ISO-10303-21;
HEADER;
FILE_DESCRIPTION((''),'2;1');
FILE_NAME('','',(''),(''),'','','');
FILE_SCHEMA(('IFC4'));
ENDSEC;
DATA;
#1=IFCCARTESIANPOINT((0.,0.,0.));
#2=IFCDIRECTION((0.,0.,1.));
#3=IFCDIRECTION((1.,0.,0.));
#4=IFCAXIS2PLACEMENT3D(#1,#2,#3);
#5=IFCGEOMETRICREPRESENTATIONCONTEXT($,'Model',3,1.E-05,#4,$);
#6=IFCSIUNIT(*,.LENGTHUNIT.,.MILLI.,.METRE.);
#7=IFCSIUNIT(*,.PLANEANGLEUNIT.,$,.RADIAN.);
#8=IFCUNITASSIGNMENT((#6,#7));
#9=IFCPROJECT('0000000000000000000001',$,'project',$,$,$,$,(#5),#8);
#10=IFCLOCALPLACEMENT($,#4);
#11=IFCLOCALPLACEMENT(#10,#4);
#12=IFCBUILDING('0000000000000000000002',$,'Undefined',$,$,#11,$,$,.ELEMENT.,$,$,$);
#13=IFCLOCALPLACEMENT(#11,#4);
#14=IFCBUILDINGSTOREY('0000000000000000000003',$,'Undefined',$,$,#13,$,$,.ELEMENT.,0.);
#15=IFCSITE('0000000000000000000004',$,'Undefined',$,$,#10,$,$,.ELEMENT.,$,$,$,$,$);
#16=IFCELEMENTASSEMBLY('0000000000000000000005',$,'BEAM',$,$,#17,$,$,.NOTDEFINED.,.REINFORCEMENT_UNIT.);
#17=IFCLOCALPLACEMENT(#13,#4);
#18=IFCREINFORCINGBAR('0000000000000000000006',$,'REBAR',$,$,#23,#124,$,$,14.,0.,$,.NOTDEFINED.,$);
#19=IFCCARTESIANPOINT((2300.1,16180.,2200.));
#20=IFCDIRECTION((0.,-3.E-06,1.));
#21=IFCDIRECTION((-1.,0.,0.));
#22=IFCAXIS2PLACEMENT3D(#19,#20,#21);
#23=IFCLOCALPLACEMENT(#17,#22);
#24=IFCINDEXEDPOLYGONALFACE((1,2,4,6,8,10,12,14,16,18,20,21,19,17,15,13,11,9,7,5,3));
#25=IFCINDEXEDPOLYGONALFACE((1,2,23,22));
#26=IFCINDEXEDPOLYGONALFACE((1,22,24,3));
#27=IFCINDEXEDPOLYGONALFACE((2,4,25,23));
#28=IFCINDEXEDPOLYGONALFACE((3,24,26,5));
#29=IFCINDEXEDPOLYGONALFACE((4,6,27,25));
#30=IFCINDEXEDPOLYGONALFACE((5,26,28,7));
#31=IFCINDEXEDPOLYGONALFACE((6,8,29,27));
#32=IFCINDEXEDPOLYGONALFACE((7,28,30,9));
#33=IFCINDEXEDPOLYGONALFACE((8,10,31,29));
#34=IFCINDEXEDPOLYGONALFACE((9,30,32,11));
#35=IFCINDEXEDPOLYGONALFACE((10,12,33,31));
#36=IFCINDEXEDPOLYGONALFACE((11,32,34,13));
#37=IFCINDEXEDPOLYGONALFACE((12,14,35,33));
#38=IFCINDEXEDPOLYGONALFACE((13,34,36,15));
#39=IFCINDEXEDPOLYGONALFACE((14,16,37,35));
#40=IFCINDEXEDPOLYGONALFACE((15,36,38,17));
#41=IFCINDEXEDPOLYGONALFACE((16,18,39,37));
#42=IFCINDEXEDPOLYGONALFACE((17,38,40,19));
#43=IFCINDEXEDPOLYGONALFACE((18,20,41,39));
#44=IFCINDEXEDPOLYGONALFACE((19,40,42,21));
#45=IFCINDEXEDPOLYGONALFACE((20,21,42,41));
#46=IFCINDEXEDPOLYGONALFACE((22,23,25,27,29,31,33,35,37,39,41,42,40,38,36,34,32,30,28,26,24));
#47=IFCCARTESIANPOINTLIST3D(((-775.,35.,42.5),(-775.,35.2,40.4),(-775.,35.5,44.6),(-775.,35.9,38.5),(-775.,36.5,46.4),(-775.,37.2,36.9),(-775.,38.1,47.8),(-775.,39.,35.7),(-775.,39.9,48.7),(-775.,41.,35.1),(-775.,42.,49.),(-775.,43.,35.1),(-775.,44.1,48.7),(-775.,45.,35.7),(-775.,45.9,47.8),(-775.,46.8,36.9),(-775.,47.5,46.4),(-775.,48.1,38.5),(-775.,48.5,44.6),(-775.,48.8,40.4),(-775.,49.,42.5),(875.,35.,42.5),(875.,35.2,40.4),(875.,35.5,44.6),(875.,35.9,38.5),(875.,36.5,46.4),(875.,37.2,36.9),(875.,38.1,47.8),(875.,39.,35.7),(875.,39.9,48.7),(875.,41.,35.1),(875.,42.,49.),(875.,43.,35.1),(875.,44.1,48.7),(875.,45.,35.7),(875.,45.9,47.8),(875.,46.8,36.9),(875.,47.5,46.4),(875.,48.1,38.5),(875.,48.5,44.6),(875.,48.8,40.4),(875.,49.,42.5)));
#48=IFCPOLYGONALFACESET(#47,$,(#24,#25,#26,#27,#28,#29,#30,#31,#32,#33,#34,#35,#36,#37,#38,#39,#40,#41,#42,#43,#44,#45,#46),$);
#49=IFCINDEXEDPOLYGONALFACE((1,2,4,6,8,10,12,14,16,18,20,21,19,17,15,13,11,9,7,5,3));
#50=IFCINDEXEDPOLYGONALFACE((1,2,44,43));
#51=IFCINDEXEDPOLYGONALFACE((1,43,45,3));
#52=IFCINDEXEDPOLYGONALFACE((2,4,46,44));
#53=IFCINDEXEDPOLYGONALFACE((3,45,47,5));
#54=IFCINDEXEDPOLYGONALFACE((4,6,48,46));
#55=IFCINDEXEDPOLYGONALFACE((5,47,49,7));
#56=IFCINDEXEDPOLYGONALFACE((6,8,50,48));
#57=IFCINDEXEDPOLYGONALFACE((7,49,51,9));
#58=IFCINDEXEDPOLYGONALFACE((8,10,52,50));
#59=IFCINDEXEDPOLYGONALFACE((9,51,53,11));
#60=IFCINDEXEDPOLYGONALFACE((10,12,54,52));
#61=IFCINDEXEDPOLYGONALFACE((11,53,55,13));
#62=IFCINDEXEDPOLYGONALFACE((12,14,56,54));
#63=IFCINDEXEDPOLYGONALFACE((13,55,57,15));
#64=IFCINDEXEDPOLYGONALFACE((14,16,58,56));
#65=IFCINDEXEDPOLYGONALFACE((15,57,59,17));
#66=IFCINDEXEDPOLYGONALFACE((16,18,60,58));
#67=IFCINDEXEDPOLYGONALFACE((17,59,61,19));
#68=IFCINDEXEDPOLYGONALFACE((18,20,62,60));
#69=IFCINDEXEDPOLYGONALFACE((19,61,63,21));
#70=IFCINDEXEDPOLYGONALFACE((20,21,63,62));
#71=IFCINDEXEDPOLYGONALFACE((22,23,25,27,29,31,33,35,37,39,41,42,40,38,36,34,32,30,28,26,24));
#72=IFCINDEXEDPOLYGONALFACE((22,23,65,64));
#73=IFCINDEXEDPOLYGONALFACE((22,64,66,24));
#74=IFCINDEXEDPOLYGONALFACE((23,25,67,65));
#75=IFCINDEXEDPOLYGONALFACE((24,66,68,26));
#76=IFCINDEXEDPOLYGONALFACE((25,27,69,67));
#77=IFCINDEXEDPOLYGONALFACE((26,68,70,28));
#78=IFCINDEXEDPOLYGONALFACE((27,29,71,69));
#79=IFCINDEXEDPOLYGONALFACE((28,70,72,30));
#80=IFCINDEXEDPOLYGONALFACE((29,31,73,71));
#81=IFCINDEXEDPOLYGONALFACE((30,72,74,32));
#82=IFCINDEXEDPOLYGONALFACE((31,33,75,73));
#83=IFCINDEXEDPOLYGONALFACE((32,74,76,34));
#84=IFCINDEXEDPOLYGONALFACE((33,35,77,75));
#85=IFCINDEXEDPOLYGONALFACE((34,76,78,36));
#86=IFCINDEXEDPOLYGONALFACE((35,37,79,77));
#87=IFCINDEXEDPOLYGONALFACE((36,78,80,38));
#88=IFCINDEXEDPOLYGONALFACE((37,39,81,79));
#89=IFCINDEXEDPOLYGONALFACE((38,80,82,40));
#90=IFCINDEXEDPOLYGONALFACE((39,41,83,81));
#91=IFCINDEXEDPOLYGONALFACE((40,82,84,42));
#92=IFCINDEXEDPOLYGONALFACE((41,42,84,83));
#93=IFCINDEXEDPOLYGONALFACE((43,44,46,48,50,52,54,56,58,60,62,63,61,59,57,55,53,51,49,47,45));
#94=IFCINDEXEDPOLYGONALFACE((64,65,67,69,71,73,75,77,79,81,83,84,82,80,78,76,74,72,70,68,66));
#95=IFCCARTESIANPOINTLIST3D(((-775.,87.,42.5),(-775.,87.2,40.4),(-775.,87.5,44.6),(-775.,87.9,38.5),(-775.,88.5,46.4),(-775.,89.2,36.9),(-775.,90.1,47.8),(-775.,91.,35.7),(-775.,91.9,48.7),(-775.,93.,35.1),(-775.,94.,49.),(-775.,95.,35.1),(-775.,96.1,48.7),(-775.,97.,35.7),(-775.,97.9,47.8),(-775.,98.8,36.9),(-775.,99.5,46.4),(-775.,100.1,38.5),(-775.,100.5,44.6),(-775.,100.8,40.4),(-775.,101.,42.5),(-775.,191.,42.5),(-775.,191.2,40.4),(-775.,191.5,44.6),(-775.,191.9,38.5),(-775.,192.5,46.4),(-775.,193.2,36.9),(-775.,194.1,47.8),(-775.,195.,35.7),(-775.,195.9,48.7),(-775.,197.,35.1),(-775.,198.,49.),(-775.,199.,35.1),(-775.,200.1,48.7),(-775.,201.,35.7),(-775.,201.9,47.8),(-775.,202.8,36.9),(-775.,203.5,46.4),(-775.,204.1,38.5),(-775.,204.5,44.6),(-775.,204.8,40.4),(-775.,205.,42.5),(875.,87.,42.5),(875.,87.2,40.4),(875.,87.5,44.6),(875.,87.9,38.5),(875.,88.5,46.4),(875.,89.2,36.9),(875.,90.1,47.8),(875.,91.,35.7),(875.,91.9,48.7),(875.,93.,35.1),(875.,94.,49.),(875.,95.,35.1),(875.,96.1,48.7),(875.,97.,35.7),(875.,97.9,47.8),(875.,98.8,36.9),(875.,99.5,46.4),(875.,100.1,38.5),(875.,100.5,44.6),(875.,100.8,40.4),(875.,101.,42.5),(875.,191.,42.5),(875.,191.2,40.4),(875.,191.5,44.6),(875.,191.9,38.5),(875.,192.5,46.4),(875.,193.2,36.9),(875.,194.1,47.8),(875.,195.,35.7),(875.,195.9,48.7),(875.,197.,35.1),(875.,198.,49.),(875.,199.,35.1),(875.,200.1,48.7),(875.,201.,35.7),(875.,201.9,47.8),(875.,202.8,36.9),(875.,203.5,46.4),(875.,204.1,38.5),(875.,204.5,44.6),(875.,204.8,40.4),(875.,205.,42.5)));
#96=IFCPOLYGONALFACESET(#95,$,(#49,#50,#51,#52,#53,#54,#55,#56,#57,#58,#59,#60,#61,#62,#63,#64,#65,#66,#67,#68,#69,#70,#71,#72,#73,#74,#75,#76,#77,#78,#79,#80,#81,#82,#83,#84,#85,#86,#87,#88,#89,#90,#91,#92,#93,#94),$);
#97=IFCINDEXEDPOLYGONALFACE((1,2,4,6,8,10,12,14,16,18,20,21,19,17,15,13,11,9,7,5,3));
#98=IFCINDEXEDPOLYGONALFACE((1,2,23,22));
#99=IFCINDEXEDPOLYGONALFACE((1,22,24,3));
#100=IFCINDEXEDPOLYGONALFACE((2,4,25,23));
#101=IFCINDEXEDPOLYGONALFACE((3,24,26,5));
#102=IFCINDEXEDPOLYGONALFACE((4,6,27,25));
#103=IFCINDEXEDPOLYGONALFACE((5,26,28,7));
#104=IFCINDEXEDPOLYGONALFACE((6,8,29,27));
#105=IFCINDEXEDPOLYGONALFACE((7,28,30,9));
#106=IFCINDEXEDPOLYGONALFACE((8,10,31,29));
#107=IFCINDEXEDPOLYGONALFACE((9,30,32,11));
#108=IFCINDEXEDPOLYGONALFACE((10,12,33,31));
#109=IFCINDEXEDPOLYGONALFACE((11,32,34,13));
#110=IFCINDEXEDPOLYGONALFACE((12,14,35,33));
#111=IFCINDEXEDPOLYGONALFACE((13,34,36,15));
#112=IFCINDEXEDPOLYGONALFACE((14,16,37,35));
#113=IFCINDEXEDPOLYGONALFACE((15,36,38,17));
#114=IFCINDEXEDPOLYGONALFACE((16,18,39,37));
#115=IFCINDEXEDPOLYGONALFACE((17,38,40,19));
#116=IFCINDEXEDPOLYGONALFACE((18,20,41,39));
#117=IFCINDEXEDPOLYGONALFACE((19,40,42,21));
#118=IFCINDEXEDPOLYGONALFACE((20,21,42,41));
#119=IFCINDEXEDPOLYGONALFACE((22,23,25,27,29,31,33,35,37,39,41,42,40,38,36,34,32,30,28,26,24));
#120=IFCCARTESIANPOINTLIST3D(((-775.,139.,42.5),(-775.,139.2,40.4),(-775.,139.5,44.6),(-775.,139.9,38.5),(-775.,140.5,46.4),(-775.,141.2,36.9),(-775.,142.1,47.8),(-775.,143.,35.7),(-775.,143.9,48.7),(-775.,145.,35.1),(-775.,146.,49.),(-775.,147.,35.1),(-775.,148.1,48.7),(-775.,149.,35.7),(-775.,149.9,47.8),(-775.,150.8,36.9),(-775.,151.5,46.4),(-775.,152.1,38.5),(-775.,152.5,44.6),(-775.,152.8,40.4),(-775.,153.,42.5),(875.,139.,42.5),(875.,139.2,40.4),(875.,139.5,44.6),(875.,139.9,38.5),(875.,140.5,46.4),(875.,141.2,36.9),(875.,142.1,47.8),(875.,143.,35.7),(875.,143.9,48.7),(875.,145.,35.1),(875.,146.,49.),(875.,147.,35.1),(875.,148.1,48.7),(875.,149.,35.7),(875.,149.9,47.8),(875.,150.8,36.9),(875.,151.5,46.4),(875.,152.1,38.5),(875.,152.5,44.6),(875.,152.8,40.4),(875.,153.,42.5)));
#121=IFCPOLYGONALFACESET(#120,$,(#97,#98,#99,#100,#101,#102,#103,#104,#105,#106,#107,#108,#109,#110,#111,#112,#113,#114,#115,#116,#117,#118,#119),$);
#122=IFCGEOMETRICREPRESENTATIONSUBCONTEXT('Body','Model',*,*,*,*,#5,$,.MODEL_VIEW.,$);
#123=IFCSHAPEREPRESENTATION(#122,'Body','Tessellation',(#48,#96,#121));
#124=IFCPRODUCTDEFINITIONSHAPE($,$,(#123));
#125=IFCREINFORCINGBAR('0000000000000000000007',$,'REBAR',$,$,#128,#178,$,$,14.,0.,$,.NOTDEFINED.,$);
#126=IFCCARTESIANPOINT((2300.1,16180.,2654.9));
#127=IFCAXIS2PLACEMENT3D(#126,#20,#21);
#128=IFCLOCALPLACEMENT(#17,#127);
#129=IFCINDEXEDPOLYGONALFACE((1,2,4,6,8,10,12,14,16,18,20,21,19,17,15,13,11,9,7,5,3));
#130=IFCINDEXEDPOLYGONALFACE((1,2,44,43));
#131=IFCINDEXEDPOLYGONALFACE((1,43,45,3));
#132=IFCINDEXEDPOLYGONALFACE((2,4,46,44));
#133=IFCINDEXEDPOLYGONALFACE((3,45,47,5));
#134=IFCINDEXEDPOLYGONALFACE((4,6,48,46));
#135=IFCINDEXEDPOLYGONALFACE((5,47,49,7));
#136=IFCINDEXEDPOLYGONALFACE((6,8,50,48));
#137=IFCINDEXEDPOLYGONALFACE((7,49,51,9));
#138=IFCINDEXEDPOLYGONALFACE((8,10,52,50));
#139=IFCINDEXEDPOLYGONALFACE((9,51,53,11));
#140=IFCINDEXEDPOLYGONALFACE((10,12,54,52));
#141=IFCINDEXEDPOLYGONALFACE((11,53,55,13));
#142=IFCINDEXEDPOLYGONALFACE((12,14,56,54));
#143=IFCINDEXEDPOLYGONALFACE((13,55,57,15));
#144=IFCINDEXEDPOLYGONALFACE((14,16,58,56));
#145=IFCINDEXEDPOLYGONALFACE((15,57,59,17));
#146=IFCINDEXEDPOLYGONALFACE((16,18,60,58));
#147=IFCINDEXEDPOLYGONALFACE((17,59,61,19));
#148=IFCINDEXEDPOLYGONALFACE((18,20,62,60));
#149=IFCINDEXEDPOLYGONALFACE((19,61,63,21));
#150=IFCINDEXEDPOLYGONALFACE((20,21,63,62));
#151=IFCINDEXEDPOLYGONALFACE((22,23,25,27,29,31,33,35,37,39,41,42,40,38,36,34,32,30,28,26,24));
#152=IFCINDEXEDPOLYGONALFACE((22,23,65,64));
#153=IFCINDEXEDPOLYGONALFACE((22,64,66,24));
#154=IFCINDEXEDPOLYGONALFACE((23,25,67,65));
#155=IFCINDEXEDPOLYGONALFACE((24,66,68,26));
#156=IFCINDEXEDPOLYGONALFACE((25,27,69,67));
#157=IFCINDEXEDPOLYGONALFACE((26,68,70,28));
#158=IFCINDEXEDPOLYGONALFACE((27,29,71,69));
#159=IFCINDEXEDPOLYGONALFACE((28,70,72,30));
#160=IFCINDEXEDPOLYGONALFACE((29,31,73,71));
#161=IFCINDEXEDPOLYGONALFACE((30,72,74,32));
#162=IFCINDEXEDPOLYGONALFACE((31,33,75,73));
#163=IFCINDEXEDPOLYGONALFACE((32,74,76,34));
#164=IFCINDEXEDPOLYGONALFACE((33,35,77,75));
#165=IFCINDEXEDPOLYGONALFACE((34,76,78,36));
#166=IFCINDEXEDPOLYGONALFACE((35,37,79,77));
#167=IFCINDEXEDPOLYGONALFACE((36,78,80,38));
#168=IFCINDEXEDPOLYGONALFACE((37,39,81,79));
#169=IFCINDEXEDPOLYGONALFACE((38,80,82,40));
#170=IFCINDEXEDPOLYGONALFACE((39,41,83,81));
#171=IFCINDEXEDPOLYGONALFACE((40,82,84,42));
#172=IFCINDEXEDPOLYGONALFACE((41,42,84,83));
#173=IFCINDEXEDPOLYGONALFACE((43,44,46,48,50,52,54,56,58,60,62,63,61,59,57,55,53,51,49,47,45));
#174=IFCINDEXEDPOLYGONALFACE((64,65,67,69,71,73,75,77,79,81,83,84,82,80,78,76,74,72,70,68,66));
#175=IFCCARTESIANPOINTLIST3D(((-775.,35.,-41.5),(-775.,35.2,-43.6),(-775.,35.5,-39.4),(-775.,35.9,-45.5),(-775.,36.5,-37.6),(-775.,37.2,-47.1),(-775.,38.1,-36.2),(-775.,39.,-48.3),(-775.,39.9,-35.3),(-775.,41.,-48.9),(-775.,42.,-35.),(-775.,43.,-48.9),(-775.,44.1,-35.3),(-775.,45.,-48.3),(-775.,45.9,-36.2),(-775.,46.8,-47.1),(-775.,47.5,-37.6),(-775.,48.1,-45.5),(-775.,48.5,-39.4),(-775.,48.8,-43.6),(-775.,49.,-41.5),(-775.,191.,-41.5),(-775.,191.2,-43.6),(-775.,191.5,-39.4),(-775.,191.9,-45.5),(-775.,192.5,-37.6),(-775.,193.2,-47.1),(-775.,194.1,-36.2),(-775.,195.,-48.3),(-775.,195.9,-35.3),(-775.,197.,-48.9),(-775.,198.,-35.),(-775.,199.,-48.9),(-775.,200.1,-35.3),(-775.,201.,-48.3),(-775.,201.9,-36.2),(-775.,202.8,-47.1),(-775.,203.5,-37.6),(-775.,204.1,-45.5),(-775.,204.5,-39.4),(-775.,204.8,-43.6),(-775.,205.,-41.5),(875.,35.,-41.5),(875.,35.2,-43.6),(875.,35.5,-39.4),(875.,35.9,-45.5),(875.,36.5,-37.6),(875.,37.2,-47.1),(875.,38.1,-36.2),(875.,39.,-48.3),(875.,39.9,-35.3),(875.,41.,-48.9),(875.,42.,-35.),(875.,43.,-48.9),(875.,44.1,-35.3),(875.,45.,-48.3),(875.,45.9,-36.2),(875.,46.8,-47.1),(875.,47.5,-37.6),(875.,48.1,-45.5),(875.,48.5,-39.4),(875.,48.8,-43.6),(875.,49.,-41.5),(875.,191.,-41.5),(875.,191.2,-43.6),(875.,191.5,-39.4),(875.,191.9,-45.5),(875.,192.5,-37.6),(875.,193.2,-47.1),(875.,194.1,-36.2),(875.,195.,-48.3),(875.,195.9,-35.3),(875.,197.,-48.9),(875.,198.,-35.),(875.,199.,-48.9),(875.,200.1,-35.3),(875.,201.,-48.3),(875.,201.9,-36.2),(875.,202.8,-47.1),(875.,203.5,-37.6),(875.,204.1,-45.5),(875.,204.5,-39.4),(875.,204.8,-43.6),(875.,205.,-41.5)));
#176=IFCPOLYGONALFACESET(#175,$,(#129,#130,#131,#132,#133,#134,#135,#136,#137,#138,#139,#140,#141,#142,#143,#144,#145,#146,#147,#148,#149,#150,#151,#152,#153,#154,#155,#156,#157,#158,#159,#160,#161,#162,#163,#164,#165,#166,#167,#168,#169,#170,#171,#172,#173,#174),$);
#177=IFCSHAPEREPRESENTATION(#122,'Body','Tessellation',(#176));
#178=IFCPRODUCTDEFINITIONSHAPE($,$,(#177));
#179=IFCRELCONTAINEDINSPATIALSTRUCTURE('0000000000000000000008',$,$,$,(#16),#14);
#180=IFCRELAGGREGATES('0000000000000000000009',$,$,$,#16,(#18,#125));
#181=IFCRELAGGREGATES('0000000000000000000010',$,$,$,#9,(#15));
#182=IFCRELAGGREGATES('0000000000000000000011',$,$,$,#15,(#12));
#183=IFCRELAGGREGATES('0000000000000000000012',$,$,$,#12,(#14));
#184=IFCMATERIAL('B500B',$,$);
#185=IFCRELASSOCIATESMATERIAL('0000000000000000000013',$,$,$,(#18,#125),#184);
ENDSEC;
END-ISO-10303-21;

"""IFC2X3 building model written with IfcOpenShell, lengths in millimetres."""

from ifc_helpers import new_model, entity, si_unit, frame, origin_with_axes, place, context, subcontext, project, spatial, source, transform, mapped, material, element, aggregate, save


model = new_model("IFC2X3")

# Units and contexts
model_context = context("Model", 3, precision=1e-05, world=origin_with_axes())
body_context = subcontext(model_context, "Body", "Model", "MODEL_VIEW")
ifc_project = project(units=[si_unit("LENGTHUNIT", "METRE", prefix="MILLI"), si_unit("PLANEANGLEUNIT", "RADIAN")], contexts=[model_context])

# Site, building, storey
site_placement = place(None, origin_with_axes())
site = spatial("IfcSite", under=ifc_project, at=site_placement, Name="Undefined", CompositionType="ELEMENT")
building_placement = place(site_placement, origin_with_axes())
building = spatial("IfcBuilding", under=site, at=building_placement, Name="Undefined", CompositionType="ELEMENT")
storey_placement = place(building_placement, origin_with_axes())
storey = spatial("IfcBuildingStorey", under=building, at=storey_placement, Name="Undefined", CompositionType="ELEMENT", Elevation=0.0)

# Element assembly
assembly_1_placement = place(storey_placement, origin_with_axes())
assembly_1 = element("IfcElementAssembly", 1, at=assembly_1_placement, inside=storey, Name="BEAM", AssemblyPlace="NOTDEFINED", PredefinedType="REINFORCEMENT_UNIT")

# Reinforcing bars
ifc_material_1 = material(Name="B500B")
shared_shape_1 = source(origin_with_axes(), body_context, "Body", "AdvancedSweptSolid", [
    entity("IfcSweptDiskSolid", entity("IfcTrimmedCurve", entity("IfcLine", entity("IfcCartesianPoint", [0.0, 0.0, 0.0]), entity("IfcVector", entity("IfcDirection", [1.0, 0.0, 0.0]), 1.0)), [entity("IfcParameterValue", 0.0)], [entity("IfcParameterValue", 1649.999613)], True, "PARAMETER"), 7.0, None, 0.0, 1650.0),
])
shared_shape_2 = source(origin_with_axes(), body_context, "Body", "AdvancedSweptSolid", [
    entity("IfcSweptDiskSolid", entity("IfcTrimmedCurve", entity("IfcLine", entity("IfcCartesianPoint", [0.0, 0.0, 0.0]), entity("IfcVector", entity("IfcDirection", [1.0, 0.0, 0.0]), 1.0)), [entity("IfcParameterValue", 0.0)], [entity("IfcParameterValue", 1649.999613)], True, "PARAMETER"), 7.0, None, 0.0, 1650.0),
])
shared_shape_3 = source(origin_with_axes(), body_context, "Body", "AdvancedSweptSolid", [
    entity("IfcSweptDiskSolid", entity("IfcTrimmedCurve", entity("IfcLine", entity("IfcCartesianPoint", [0.0, 0.0, 0.0]), entity("IfcVector", entity("IfcDirection", [1.0, 0.0, 0.0]), 1.0)), [entity("IfcParameterValue", 0.0)], [entity("IfcParameterValue", 1649.999613)], True, "PARAMETER"), 7.0, None, 0.0, 1650.0),
])
shared_shape_4 = source(origin_with_axes(), body_context, "Body", "AdvancedSweptSolid", [
    entity("IfcSweptDiskSolid", entity("IfcTrimmedCurve", entity("IfcLine", entity("IfcCartesianPoint", [0.0, 0.0, 0.0]), entity("IfcVector", entity("IfcDirection", [1.0, 0.0, 0.0]), 1.0)), [entity("IfcParameterValue", 0.0)], [entity("IfcParameterValue", 1649.999613)], True, "PARAMETER"), 7.0, None, 0.0, 1650.0),
])
reinforcing_bar_1_placement = place(assembly_1_placement, frame((2300.1, 16180.0, 2200.0), z_axis=(0.0, -0.000003, 1.0), x_axis=(-1.0, 0.0, 0.0)))
reinforcing_bar_1 = element("IfcReinforcingBar", 2, at=reinforcing_bar_1_placement, material=ifc_material_1, Name="REBAR", BarRole="NOTDEFINED", CrossSectionArea=0.0, NominalDiameter=14.0, context=body_context, shape_type="MappedRepresentation", body=[
    mapped(shared_shape_1, transform((-775.0, 42.0, 42.0))),
    mapped(shared_shape_2, transform((-775.0, 94.0, 42.0))),
    mapped(shared_shape_3, transform((-775.0, 146.0, 42.0))),
    mapped(shared_shape_4, transform((-775.0, 198.0, 42.0))),
])
shared_shape_5 = source(origin_with_axes(), body_context, "Body", "AdvancedSweptSolid", [
    entity("IfcSweptDiskSolid", entity("IfcTrimmedCurve", entity("IfcLine", entity("IfcCartesianPoint", [0.0, 0.0, 0.0]), entity("IfcVector", entity("IfcDirection", [1.0, 0.0, 0.0]), 1.0)), [entity("IfcParameterValue", 0.0)], [entity("IfcParameterValue", 1649.999613)], True, "PARAMETER"), 7.0, None, 0.0, 1650.0),
])
shared_shape_6 = source(origin_with_axes(), body_context, "Body", "AdvancedSweptSolid", [
    entity("IfcSweptDiskSolid", entity("IfcTrimmedCurve", entity("IfcLine", entity("IfcCartesianPoint", [0.0, 0.0, 0.0]), entity("IfcVector", entity("IfcDirection", [1.0, 0.0, 0.0]), 1.0)), [entity("IfcParameterValue", 0.0)], [entity("IfcParameterValue", 1649.999613)], True, "PARAMETER"), 7.0, None, 0.0, 1650.0),
])
reinforcing_bar_2_placement = place(assembly_1_placement, frame((2300.1, 16180.0, 2654.9), z_axis=(0.0, -0.000003, 1.0), x_axis=(-1.0, 0.0, 0.0)))
reinforcing_bar_2 = element("IfcReinforcingBar", 3, at=reinforcing_bar_2_placement, material=ifc_material_1, Name="REBAR", BarRole="NOTDEFINED", CrossSectionArea=0.0, NominalDiameter=14.0, context=body_context, shape_type="MappedRepresentation", body=[
    mapped(shared_shape_5, transform((-775.0, 42.0, -42.0))),
    mapped(shared_shape_6, transform((-775.0, 198.0, -42.0))),
])
aggregate(assembly_1, [reinforcing_bar_1, reinforcing_bar_2])

save(model, "model.ifc")
